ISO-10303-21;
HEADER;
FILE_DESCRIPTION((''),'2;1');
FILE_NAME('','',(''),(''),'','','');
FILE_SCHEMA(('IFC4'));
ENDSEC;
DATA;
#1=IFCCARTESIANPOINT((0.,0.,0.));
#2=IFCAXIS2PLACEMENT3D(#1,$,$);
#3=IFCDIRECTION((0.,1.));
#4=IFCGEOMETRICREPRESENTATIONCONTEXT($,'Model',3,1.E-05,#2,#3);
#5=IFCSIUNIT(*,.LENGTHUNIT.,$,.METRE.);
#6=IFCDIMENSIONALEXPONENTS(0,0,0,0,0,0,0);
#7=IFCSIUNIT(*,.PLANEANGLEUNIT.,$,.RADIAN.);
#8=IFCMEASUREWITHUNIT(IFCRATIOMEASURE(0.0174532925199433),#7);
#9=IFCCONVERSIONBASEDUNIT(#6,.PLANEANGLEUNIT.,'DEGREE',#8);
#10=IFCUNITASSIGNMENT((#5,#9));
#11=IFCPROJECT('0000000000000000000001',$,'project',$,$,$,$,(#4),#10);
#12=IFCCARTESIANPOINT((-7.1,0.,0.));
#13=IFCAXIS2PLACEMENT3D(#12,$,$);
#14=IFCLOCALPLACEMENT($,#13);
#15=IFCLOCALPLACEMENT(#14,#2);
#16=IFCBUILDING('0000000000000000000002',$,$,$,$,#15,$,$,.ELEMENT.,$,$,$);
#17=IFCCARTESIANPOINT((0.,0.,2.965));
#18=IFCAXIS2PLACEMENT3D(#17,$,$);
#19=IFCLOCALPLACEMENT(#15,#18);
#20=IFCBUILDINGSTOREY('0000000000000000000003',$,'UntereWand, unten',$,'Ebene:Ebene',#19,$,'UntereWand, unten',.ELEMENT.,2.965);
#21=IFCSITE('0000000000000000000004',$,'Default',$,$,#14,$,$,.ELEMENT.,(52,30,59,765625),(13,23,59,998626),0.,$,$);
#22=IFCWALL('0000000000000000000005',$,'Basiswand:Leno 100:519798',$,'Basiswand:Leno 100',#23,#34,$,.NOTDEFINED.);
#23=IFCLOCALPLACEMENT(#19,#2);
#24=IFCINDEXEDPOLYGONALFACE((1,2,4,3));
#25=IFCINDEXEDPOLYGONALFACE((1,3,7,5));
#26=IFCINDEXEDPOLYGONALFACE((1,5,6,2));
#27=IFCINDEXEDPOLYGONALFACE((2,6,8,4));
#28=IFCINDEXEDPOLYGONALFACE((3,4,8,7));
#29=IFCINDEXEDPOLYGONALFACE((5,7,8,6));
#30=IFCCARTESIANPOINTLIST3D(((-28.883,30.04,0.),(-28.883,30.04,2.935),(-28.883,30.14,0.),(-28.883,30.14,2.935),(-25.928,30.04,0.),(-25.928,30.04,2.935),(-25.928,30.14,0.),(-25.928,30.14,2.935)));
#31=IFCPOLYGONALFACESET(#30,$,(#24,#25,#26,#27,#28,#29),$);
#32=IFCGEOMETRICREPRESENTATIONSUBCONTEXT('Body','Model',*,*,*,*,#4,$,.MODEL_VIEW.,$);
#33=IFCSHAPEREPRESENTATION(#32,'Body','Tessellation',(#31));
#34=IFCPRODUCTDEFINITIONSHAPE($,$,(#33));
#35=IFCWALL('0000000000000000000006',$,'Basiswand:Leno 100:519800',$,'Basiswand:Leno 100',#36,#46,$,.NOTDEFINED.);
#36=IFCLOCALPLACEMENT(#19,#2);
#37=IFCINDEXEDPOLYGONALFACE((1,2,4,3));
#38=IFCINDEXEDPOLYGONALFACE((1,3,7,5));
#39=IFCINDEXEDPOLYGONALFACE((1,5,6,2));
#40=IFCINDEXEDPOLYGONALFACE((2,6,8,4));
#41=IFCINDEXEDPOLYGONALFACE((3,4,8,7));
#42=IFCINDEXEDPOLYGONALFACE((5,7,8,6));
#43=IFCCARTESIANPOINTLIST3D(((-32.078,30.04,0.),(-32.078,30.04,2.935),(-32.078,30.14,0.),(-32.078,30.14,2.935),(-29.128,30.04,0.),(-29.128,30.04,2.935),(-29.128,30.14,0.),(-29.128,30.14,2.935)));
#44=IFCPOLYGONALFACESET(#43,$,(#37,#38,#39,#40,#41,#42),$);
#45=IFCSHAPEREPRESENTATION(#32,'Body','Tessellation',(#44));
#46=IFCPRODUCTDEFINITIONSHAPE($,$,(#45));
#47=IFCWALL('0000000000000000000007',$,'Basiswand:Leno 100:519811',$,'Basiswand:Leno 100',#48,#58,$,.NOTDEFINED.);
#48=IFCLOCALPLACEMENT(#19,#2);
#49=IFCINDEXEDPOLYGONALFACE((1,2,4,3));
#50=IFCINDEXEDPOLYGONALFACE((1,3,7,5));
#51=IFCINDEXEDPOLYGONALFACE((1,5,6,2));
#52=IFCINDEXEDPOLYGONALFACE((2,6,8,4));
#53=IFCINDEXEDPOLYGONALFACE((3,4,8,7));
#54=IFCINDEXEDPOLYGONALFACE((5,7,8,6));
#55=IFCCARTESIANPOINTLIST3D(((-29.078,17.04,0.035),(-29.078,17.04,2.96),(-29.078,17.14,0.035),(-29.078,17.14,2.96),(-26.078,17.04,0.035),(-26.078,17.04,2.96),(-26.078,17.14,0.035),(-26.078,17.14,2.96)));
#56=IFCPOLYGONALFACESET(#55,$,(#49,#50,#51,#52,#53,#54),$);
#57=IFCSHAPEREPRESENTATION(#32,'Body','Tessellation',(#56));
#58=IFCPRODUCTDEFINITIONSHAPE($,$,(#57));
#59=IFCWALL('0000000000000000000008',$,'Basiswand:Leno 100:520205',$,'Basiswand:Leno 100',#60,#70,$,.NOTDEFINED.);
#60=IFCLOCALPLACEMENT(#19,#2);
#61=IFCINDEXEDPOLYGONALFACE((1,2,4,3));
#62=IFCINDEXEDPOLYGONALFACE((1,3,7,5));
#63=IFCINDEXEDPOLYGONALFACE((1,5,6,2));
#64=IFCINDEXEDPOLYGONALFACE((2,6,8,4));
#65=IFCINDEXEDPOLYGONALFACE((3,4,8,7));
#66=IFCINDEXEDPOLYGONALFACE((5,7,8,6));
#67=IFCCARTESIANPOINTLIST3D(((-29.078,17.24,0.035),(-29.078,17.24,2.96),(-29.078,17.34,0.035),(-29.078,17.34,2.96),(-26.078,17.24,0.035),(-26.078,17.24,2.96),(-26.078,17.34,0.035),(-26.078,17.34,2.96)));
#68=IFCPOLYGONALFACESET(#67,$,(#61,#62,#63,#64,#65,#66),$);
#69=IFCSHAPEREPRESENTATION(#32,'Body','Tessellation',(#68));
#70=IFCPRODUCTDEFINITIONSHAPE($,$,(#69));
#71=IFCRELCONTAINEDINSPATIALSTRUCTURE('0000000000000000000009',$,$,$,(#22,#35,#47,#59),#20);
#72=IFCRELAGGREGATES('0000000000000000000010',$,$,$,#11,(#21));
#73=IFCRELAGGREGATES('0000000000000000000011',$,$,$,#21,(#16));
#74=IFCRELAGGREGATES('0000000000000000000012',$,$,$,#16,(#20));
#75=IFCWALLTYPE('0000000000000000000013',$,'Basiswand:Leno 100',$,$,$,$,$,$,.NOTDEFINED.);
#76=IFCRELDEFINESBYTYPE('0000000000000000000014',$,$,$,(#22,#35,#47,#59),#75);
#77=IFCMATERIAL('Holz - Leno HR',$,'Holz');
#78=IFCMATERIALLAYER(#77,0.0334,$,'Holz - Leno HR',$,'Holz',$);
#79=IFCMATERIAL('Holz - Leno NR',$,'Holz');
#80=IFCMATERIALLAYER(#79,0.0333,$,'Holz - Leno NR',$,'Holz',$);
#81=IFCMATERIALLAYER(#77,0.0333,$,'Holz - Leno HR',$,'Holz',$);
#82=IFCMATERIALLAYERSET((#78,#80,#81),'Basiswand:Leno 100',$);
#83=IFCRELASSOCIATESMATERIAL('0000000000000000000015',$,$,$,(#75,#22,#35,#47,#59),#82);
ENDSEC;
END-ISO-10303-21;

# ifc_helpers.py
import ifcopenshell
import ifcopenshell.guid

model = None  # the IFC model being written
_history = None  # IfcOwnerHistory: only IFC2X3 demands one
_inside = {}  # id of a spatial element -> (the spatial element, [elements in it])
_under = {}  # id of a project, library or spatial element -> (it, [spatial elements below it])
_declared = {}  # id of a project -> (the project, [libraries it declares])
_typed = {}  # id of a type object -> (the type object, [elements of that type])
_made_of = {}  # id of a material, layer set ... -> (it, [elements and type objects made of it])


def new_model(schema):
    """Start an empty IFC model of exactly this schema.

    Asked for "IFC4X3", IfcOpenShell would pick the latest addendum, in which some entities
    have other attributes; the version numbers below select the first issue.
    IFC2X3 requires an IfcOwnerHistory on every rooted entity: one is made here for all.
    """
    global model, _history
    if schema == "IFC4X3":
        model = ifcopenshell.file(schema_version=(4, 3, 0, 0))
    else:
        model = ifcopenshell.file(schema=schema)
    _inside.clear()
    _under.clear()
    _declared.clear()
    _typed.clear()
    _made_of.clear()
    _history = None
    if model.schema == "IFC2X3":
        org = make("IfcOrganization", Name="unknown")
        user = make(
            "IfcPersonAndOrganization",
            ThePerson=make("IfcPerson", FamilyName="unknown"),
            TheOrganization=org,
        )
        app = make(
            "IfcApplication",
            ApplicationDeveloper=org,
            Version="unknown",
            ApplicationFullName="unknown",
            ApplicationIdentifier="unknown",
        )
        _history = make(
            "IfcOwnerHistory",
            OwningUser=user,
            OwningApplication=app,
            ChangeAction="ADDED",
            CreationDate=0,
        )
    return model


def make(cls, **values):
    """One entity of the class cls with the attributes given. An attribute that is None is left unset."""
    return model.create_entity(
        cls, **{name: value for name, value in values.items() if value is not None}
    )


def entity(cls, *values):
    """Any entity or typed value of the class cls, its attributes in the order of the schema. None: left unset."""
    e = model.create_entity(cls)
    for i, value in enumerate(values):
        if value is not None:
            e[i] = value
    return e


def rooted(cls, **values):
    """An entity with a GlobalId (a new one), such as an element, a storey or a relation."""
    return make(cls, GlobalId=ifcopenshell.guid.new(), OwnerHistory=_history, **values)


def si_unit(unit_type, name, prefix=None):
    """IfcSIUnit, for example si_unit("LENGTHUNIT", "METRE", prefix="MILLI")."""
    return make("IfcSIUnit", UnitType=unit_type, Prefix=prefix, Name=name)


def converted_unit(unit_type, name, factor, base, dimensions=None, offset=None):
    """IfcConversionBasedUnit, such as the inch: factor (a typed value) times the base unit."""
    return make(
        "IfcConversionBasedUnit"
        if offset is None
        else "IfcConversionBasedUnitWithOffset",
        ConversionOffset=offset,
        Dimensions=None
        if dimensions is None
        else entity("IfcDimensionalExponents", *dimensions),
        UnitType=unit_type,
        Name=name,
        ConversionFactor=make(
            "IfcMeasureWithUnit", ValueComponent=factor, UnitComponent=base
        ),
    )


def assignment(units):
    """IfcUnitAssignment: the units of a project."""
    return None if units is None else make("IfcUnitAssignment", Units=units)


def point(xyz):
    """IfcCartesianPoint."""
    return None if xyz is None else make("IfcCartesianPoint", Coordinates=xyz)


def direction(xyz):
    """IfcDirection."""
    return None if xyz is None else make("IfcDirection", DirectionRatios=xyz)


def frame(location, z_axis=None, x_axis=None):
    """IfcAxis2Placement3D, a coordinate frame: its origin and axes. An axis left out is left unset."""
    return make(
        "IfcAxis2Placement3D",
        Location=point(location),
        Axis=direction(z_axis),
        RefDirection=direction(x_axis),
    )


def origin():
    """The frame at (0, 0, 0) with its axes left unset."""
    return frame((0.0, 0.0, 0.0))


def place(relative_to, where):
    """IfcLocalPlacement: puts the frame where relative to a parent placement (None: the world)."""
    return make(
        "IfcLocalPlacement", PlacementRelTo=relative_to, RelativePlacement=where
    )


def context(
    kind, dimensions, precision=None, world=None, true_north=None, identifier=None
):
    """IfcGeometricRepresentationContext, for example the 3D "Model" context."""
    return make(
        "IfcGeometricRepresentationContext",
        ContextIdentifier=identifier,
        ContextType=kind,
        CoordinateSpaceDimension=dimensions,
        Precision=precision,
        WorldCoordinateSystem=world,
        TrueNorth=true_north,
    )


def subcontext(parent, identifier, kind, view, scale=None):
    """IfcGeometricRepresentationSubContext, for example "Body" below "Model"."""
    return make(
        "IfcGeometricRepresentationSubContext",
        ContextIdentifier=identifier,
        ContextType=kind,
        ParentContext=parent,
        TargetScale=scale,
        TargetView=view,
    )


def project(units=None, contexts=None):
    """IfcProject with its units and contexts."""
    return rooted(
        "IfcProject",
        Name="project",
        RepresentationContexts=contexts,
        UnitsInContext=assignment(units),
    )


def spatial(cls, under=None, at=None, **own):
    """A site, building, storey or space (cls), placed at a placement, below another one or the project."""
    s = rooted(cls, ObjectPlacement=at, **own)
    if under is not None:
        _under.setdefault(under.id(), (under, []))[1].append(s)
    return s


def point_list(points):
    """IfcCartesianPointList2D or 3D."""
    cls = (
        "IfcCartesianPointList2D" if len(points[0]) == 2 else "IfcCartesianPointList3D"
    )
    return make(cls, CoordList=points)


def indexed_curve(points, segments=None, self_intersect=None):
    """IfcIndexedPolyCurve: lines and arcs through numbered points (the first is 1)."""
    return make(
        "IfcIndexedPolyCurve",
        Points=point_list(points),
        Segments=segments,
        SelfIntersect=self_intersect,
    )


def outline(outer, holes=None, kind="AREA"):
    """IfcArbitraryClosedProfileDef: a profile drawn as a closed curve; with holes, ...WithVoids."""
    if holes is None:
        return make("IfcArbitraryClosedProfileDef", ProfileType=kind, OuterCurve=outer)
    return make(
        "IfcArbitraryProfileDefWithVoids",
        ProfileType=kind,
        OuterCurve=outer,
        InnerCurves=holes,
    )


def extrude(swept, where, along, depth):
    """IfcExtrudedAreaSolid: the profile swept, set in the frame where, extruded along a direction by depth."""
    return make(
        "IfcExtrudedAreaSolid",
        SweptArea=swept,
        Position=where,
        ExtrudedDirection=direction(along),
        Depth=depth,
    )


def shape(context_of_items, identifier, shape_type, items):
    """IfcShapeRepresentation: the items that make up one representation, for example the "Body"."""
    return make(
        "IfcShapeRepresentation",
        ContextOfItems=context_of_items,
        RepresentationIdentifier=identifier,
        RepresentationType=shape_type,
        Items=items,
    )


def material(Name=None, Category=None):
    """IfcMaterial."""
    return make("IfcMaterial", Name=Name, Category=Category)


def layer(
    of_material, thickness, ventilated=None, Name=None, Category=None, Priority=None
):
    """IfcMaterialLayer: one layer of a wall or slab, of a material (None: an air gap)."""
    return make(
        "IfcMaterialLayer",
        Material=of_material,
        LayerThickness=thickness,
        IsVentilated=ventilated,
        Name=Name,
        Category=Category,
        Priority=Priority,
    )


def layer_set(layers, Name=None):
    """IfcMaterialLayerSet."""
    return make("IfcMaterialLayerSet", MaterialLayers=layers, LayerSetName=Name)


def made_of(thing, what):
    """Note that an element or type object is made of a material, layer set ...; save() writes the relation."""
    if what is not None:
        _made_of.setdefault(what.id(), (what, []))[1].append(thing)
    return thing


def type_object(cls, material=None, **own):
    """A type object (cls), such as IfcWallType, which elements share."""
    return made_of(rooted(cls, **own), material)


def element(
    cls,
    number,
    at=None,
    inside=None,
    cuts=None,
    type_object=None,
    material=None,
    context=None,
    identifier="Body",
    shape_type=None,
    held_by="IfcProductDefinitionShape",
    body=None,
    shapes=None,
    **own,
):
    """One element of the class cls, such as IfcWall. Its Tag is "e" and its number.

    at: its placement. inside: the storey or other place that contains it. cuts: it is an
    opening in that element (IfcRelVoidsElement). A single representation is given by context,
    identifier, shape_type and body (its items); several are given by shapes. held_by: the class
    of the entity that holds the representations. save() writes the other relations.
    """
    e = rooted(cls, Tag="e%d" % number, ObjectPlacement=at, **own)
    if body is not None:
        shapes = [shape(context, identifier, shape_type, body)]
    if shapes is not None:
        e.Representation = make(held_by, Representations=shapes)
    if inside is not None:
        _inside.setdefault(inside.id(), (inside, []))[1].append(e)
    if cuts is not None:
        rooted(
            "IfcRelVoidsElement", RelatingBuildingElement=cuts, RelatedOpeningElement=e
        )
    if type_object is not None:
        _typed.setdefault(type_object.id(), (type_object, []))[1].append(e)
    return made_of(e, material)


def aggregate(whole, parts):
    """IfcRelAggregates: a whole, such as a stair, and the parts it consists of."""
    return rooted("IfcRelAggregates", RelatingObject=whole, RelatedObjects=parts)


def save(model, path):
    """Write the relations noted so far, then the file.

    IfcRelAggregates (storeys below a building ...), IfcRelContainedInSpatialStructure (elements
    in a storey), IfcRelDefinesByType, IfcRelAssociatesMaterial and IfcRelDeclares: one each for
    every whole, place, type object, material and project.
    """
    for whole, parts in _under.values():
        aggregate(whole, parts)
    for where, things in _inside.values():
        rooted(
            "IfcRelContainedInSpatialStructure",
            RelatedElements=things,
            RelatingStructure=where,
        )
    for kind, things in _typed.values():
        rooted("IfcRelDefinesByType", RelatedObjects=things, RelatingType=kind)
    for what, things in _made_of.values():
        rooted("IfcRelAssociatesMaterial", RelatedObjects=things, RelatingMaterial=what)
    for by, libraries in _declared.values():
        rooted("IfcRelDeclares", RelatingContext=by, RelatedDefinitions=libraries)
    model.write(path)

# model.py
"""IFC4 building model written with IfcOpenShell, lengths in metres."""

from ifc_helpers import new_model, entity, si_unit, converted_unit, direction, frame, origin, place, context, subcontext, project, spatial, indexed_curve, outline, extrude, material, layer, layer_set, type_object, element, save


model = new_model("IFC4")

# Units and contexts
model_context = context("Model", 3, precision=1e-05, world=origin(), true_north=direction((0.0, 1.0)))
body_context = subcontext(model_context, "Body", "Model", "MODEL_VIEW")
ifc_project = project(units=[si_unit("LENGTHUNIT", "METRE"), converted_unit("PLANEANGLEUNIT", "DEGREE", entity("IfcRatioMeasure", 0.0174532925199433), si_unit("PLANEANGLEUNIT", "RADIAN"), dimensions=[0, 0, 0, 0, 0, 0, 0])], contexts=[model_context])

# Site, building, storey
site_placement = place(None, frame((-7.1, 0.0, 0.0)))
site = spatial("IfcSite", under=ifc_project, at=site_placement, Name="Default", CompositionType="ELEMENT", RefLatitude=(52, 30, 59, 765625), RefLongitude=(13, 23, 59, 998626), RefElevation=0.0)
building_placement = place(site_placement, origin())
building = spatial("IfcBuilding", under=site, at=building_placement, CompositionType="ELEMENT")
storey_placement = place(building_placement, frame((0.0, 0.0, 2.965)))
storey = spatial("IfcBuildingStorey", under=building, at=storey_placement, Name="UntereWand, unten", ObjectType="Ebene:Ebene", LongName="UntereWand, unten", CompositionType="ELEMENT", Elevation=2.965)

# Walls
ifc_material_1 = material(Name="Holz - Leno HR", Category="Holz")
ifc_layer_1 = layer(ifc_material_1, 0.0334, Name="Holz - Leno HR", Category="Holz")
ifc_material_2 = material(Name="Holz - Leno NR", Category="Holz")
ifc_layer_2 = layer(ifc_material_2, 0.0333, Name="Holz - Leno NR", Category="Holz")
ifc_layer_3 = layer(ifc_material_1, 0.0333, Name="Holz - Leno HR", Category="Holz")
ifc_layer_set = layer_set([ifc_layer_1, ifc_layer_2, ifc_layer_3], Name="Basiswand:Leno 100")
wall_type = type_object("IfcWallType", Name="Basiswand:Leno 100", PredefinedType="NOTDEFINED", material=ifc_layer_set)
wall_1_placement = place(storey_placement, frame((-25.928, 30.09, 0.0), z_axis=(0.0, 0.0, 1.0), x_axis=(-1.0, 0.0, 0.0)))
element("IfcWall", 1, at=wall_1_placement, inside=storey, type_object=wall_type, material=ifc_layer_set, Name="Basiswand:Leno 100:519798", ObjectType="Basiswand:Leno 100", PredefinedType="NOTDEFINED", context=body_context, shape_type="SweptSolid", body=[
    extrude(outline(indexed_curve([(2.955, 0.05), (0.0, 0.05), (0.0, -0.05), (2.955, -0.05), (2.955, 0.05)], self_intersect=False)), origin(), (0.0, 0.0, 1.0), 2.935),
])
wall_2_placement = place(storey_placement, frame((-32.078, 30.09, 0.0)))
element("IfcWall", 2, at=wall_2_placement, inside=storey, type_object=wall_type, material=ifc_layer_set, Name="Basiswand:Leno 100:519800", ObjectType="Basiswand:Leno 100", PredefinedType="NOTDEFINED", context=body_context, shape_type="SweptSolid", body=[
    extrude(outline(indexed_curve([(2.95, 0.05), (0.0, 0.05), (0.0, -0.05), (2.95, -0.05), (2.95, 0.05)], self_intersect=False)), origin(), (0.0, 0.0, 1.0), 2.935),
])
for number, where, z_axis, x_axis, name in (
    (3, (-26.078, 17.09, 0.035), (0.0, 0.0, 1.0), (-1.0, 0.0, 0.0), "Basiswand:Leno 100:519811"),
    (4, (-26.078, 17.29, 0.035), (0.0, 0.0, 1.0), (-1.0, 0.0, 0.0), "Basiswand:Leno 100:520205"),
):
    element("IfcWall", number, at=place(storey_placement, frame(where, z_axis=z_axis, x_axis=x_axis)), inside=storey, type_object=wall_type, material=ifc_layer_set, Name=name, ObjectType="Basiswand:Leno 100", PredefinedType="NOTDEFINED", context=body_context, shape_type="SweptSolid", body=[
        extrude(outline(indexed_curve([(3.0, 0.05), (0.0, 0.05), (0.0, -0.05), (3.0, -0.05), (3.0, 0.05)], self_intersect=False)), origin(), (0.0, 0.0, 1.0), 2.925),
    ])

save(model, "model.ifc")
